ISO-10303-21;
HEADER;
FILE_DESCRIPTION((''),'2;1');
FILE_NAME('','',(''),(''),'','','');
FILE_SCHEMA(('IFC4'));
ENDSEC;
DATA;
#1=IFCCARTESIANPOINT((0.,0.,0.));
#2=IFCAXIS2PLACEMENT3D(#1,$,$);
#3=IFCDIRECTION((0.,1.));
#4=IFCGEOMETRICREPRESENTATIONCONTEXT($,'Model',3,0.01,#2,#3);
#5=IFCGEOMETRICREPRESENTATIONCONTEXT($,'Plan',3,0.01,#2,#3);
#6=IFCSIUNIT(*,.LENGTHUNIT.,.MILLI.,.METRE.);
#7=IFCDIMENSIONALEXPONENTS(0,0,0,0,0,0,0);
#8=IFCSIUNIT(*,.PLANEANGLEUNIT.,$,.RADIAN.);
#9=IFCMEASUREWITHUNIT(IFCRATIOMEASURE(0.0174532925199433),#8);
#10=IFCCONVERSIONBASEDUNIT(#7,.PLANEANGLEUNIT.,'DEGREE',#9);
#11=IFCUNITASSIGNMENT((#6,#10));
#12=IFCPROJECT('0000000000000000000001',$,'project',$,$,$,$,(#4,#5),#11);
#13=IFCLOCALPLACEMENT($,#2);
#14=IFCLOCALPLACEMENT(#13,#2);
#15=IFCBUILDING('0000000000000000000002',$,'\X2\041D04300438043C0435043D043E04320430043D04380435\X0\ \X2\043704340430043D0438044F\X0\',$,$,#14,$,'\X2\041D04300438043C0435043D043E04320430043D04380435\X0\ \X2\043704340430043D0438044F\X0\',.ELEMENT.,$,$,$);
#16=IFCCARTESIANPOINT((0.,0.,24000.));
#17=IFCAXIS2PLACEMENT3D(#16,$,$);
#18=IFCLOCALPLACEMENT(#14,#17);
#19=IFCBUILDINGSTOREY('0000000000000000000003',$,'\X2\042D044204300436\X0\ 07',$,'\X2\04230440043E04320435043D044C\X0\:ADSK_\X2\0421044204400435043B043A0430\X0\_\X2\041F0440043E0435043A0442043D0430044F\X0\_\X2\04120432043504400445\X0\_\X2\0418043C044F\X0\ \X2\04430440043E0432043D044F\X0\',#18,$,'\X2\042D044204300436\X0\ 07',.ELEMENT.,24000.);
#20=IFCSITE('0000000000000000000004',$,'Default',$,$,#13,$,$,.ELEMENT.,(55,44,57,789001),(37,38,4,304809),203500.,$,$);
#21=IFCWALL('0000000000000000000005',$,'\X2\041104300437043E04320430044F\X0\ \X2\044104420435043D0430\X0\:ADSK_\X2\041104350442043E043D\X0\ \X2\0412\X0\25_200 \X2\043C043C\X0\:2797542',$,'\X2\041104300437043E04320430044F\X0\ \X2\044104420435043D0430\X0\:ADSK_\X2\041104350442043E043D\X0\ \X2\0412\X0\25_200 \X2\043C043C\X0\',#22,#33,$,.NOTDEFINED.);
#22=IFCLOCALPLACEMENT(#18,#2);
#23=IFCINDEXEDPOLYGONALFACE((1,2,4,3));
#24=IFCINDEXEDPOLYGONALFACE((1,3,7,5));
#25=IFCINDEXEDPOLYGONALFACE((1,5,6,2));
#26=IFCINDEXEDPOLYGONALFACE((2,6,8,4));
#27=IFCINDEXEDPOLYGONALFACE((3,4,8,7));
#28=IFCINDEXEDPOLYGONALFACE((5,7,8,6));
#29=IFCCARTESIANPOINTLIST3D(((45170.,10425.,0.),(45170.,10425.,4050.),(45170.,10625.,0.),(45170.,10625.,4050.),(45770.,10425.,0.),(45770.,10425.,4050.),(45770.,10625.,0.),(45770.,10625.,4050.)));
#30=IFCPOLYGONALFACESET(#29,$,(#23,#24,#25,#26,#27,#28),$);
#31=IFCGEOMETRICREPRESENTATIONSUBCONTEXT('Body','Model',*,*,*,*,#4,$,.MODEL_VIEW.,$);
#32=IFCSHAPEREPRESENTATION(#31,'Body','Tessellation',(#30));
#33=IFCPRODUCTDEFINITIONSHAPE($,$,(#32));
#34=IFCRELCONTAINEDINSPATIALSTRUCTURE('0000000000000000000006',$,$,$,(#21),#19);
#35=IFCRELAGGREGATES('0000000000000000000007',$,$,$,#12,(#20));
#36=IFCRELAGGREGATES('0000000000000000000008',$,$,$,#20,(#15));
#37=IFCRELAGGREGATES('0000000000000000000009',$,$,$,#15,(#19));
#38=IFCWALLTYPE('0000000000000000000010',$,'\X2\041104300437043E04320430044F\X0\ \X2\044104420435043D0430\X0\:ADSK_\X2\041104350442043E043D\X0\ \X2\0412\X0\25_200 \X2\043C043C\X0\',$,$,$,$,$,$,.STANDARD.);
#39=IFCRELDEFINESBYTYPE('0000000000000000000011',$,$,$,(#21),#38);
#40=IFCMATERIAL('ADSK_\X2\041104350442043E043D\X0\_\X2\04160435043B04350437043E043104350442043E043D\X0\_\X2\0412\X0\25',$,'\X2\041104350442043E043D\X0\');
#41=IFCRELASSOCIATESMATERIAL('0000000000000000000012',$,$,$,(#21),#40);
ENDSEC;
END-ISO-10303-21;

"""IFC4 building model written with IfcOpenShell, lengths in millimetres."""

from ifc_helpers import new_model, entity, si_unit, converted_unit, direction, frame, origin, place, context, subcontext, project, spatial, indexed_curve, outline, extrude, material, type_object, element, save


model = new_model("IFC4")

# Units and contexts
model_context = context("Model", 3, precision=0.01, world=origin(), true_north=direction((0.0, 1.0)))
plan_context = context("Plan", 3, precision=0.01, world=origin(), true_north=direction((0.0, 1.0)))
body_context = subcontext(model_context, "Body", "Model", "MODEL_VIEW")
ifc_project = project(units=[si_unit("LENGTHUNIT", "METRE", prefix="MILLI"), converted_unit("PLANEANGLEUNIT", "DEGREE", entity("IfcRatioMeasure", 0.0174532925199433), si_unit("PLANEANGLEUNIT", "RADIAN"), dimensions=[0, 0, 0, 0, 0, 0, 0])], contexts=[model_context, plan_context])

# Site, building, storey
site_placement = place(None, origin())
site = spatial("IfcSite", under=ifc_project, at=site_placement, Name="Default", CompositionType="ELEMENT", RefLatitude=(55, 44, 57, 789001), RefLongitude=(37, 38, 4, 304809), RefElevation=203500.0)
building_placement = place(site_placement, origin())
building = spatial("IfcBuilding", under=site, at=building_placement, Name="Наименование здания", LongName="Наименование здания", CompositionType="ELEMENT")
storey_placement = place(building_placement, frame((0.0, 0.0, 24000.0)))
storey = spatial("IfcBuildingStorey", under=building, at=storey_placement, Name="Этаж 07", ObjectType="Уровень:ADSK_Стрелка_Проектная_Вверх_Имя уровня", LongName="Этаж 07", CompositionType="ELEMENT", Elevation=24000.0)

# Shared definitions
ifc_material = material(Name="ADSK_Бетон_Железобетон_В25", Category="Бетон")

# Wall
wall_type = type_object("IfcWallType", Name="Базовая стена:ADSK_Бетон В25_200 мм", PredefinedType="STANDARD")
wall_1_placement = place(storey_placement, frame((45770.0, 10525.0, 0.0), z_axis=(0.0, 0.0, 1.0), x_axis=(-1.0, 0.0, 0.0)))
element("IfcWall", 1, at=wall_1_placement, inside=storey, type_object=wall_type, material=ifc_material, Name="Базовая стена:ADSK_Бетон В25_200 мм:2797542", ObjectType="Базовая стена:ADSK_Бетон В25_200 мм", PredefinedType="NOTDEFINED", context=body_context, shape_type="SweptSolid", body=[
    extrude(outline(indexed_curve([(600.0, 100.0), (0.0, 100.0), (0.0, -100.0), (600.0, -100.0), (600.0, 100.0)], self_intersect=False)), origin(), (0.0, 0.0, 1.0), 4050.0),
])

save(model, "model.ifc")
